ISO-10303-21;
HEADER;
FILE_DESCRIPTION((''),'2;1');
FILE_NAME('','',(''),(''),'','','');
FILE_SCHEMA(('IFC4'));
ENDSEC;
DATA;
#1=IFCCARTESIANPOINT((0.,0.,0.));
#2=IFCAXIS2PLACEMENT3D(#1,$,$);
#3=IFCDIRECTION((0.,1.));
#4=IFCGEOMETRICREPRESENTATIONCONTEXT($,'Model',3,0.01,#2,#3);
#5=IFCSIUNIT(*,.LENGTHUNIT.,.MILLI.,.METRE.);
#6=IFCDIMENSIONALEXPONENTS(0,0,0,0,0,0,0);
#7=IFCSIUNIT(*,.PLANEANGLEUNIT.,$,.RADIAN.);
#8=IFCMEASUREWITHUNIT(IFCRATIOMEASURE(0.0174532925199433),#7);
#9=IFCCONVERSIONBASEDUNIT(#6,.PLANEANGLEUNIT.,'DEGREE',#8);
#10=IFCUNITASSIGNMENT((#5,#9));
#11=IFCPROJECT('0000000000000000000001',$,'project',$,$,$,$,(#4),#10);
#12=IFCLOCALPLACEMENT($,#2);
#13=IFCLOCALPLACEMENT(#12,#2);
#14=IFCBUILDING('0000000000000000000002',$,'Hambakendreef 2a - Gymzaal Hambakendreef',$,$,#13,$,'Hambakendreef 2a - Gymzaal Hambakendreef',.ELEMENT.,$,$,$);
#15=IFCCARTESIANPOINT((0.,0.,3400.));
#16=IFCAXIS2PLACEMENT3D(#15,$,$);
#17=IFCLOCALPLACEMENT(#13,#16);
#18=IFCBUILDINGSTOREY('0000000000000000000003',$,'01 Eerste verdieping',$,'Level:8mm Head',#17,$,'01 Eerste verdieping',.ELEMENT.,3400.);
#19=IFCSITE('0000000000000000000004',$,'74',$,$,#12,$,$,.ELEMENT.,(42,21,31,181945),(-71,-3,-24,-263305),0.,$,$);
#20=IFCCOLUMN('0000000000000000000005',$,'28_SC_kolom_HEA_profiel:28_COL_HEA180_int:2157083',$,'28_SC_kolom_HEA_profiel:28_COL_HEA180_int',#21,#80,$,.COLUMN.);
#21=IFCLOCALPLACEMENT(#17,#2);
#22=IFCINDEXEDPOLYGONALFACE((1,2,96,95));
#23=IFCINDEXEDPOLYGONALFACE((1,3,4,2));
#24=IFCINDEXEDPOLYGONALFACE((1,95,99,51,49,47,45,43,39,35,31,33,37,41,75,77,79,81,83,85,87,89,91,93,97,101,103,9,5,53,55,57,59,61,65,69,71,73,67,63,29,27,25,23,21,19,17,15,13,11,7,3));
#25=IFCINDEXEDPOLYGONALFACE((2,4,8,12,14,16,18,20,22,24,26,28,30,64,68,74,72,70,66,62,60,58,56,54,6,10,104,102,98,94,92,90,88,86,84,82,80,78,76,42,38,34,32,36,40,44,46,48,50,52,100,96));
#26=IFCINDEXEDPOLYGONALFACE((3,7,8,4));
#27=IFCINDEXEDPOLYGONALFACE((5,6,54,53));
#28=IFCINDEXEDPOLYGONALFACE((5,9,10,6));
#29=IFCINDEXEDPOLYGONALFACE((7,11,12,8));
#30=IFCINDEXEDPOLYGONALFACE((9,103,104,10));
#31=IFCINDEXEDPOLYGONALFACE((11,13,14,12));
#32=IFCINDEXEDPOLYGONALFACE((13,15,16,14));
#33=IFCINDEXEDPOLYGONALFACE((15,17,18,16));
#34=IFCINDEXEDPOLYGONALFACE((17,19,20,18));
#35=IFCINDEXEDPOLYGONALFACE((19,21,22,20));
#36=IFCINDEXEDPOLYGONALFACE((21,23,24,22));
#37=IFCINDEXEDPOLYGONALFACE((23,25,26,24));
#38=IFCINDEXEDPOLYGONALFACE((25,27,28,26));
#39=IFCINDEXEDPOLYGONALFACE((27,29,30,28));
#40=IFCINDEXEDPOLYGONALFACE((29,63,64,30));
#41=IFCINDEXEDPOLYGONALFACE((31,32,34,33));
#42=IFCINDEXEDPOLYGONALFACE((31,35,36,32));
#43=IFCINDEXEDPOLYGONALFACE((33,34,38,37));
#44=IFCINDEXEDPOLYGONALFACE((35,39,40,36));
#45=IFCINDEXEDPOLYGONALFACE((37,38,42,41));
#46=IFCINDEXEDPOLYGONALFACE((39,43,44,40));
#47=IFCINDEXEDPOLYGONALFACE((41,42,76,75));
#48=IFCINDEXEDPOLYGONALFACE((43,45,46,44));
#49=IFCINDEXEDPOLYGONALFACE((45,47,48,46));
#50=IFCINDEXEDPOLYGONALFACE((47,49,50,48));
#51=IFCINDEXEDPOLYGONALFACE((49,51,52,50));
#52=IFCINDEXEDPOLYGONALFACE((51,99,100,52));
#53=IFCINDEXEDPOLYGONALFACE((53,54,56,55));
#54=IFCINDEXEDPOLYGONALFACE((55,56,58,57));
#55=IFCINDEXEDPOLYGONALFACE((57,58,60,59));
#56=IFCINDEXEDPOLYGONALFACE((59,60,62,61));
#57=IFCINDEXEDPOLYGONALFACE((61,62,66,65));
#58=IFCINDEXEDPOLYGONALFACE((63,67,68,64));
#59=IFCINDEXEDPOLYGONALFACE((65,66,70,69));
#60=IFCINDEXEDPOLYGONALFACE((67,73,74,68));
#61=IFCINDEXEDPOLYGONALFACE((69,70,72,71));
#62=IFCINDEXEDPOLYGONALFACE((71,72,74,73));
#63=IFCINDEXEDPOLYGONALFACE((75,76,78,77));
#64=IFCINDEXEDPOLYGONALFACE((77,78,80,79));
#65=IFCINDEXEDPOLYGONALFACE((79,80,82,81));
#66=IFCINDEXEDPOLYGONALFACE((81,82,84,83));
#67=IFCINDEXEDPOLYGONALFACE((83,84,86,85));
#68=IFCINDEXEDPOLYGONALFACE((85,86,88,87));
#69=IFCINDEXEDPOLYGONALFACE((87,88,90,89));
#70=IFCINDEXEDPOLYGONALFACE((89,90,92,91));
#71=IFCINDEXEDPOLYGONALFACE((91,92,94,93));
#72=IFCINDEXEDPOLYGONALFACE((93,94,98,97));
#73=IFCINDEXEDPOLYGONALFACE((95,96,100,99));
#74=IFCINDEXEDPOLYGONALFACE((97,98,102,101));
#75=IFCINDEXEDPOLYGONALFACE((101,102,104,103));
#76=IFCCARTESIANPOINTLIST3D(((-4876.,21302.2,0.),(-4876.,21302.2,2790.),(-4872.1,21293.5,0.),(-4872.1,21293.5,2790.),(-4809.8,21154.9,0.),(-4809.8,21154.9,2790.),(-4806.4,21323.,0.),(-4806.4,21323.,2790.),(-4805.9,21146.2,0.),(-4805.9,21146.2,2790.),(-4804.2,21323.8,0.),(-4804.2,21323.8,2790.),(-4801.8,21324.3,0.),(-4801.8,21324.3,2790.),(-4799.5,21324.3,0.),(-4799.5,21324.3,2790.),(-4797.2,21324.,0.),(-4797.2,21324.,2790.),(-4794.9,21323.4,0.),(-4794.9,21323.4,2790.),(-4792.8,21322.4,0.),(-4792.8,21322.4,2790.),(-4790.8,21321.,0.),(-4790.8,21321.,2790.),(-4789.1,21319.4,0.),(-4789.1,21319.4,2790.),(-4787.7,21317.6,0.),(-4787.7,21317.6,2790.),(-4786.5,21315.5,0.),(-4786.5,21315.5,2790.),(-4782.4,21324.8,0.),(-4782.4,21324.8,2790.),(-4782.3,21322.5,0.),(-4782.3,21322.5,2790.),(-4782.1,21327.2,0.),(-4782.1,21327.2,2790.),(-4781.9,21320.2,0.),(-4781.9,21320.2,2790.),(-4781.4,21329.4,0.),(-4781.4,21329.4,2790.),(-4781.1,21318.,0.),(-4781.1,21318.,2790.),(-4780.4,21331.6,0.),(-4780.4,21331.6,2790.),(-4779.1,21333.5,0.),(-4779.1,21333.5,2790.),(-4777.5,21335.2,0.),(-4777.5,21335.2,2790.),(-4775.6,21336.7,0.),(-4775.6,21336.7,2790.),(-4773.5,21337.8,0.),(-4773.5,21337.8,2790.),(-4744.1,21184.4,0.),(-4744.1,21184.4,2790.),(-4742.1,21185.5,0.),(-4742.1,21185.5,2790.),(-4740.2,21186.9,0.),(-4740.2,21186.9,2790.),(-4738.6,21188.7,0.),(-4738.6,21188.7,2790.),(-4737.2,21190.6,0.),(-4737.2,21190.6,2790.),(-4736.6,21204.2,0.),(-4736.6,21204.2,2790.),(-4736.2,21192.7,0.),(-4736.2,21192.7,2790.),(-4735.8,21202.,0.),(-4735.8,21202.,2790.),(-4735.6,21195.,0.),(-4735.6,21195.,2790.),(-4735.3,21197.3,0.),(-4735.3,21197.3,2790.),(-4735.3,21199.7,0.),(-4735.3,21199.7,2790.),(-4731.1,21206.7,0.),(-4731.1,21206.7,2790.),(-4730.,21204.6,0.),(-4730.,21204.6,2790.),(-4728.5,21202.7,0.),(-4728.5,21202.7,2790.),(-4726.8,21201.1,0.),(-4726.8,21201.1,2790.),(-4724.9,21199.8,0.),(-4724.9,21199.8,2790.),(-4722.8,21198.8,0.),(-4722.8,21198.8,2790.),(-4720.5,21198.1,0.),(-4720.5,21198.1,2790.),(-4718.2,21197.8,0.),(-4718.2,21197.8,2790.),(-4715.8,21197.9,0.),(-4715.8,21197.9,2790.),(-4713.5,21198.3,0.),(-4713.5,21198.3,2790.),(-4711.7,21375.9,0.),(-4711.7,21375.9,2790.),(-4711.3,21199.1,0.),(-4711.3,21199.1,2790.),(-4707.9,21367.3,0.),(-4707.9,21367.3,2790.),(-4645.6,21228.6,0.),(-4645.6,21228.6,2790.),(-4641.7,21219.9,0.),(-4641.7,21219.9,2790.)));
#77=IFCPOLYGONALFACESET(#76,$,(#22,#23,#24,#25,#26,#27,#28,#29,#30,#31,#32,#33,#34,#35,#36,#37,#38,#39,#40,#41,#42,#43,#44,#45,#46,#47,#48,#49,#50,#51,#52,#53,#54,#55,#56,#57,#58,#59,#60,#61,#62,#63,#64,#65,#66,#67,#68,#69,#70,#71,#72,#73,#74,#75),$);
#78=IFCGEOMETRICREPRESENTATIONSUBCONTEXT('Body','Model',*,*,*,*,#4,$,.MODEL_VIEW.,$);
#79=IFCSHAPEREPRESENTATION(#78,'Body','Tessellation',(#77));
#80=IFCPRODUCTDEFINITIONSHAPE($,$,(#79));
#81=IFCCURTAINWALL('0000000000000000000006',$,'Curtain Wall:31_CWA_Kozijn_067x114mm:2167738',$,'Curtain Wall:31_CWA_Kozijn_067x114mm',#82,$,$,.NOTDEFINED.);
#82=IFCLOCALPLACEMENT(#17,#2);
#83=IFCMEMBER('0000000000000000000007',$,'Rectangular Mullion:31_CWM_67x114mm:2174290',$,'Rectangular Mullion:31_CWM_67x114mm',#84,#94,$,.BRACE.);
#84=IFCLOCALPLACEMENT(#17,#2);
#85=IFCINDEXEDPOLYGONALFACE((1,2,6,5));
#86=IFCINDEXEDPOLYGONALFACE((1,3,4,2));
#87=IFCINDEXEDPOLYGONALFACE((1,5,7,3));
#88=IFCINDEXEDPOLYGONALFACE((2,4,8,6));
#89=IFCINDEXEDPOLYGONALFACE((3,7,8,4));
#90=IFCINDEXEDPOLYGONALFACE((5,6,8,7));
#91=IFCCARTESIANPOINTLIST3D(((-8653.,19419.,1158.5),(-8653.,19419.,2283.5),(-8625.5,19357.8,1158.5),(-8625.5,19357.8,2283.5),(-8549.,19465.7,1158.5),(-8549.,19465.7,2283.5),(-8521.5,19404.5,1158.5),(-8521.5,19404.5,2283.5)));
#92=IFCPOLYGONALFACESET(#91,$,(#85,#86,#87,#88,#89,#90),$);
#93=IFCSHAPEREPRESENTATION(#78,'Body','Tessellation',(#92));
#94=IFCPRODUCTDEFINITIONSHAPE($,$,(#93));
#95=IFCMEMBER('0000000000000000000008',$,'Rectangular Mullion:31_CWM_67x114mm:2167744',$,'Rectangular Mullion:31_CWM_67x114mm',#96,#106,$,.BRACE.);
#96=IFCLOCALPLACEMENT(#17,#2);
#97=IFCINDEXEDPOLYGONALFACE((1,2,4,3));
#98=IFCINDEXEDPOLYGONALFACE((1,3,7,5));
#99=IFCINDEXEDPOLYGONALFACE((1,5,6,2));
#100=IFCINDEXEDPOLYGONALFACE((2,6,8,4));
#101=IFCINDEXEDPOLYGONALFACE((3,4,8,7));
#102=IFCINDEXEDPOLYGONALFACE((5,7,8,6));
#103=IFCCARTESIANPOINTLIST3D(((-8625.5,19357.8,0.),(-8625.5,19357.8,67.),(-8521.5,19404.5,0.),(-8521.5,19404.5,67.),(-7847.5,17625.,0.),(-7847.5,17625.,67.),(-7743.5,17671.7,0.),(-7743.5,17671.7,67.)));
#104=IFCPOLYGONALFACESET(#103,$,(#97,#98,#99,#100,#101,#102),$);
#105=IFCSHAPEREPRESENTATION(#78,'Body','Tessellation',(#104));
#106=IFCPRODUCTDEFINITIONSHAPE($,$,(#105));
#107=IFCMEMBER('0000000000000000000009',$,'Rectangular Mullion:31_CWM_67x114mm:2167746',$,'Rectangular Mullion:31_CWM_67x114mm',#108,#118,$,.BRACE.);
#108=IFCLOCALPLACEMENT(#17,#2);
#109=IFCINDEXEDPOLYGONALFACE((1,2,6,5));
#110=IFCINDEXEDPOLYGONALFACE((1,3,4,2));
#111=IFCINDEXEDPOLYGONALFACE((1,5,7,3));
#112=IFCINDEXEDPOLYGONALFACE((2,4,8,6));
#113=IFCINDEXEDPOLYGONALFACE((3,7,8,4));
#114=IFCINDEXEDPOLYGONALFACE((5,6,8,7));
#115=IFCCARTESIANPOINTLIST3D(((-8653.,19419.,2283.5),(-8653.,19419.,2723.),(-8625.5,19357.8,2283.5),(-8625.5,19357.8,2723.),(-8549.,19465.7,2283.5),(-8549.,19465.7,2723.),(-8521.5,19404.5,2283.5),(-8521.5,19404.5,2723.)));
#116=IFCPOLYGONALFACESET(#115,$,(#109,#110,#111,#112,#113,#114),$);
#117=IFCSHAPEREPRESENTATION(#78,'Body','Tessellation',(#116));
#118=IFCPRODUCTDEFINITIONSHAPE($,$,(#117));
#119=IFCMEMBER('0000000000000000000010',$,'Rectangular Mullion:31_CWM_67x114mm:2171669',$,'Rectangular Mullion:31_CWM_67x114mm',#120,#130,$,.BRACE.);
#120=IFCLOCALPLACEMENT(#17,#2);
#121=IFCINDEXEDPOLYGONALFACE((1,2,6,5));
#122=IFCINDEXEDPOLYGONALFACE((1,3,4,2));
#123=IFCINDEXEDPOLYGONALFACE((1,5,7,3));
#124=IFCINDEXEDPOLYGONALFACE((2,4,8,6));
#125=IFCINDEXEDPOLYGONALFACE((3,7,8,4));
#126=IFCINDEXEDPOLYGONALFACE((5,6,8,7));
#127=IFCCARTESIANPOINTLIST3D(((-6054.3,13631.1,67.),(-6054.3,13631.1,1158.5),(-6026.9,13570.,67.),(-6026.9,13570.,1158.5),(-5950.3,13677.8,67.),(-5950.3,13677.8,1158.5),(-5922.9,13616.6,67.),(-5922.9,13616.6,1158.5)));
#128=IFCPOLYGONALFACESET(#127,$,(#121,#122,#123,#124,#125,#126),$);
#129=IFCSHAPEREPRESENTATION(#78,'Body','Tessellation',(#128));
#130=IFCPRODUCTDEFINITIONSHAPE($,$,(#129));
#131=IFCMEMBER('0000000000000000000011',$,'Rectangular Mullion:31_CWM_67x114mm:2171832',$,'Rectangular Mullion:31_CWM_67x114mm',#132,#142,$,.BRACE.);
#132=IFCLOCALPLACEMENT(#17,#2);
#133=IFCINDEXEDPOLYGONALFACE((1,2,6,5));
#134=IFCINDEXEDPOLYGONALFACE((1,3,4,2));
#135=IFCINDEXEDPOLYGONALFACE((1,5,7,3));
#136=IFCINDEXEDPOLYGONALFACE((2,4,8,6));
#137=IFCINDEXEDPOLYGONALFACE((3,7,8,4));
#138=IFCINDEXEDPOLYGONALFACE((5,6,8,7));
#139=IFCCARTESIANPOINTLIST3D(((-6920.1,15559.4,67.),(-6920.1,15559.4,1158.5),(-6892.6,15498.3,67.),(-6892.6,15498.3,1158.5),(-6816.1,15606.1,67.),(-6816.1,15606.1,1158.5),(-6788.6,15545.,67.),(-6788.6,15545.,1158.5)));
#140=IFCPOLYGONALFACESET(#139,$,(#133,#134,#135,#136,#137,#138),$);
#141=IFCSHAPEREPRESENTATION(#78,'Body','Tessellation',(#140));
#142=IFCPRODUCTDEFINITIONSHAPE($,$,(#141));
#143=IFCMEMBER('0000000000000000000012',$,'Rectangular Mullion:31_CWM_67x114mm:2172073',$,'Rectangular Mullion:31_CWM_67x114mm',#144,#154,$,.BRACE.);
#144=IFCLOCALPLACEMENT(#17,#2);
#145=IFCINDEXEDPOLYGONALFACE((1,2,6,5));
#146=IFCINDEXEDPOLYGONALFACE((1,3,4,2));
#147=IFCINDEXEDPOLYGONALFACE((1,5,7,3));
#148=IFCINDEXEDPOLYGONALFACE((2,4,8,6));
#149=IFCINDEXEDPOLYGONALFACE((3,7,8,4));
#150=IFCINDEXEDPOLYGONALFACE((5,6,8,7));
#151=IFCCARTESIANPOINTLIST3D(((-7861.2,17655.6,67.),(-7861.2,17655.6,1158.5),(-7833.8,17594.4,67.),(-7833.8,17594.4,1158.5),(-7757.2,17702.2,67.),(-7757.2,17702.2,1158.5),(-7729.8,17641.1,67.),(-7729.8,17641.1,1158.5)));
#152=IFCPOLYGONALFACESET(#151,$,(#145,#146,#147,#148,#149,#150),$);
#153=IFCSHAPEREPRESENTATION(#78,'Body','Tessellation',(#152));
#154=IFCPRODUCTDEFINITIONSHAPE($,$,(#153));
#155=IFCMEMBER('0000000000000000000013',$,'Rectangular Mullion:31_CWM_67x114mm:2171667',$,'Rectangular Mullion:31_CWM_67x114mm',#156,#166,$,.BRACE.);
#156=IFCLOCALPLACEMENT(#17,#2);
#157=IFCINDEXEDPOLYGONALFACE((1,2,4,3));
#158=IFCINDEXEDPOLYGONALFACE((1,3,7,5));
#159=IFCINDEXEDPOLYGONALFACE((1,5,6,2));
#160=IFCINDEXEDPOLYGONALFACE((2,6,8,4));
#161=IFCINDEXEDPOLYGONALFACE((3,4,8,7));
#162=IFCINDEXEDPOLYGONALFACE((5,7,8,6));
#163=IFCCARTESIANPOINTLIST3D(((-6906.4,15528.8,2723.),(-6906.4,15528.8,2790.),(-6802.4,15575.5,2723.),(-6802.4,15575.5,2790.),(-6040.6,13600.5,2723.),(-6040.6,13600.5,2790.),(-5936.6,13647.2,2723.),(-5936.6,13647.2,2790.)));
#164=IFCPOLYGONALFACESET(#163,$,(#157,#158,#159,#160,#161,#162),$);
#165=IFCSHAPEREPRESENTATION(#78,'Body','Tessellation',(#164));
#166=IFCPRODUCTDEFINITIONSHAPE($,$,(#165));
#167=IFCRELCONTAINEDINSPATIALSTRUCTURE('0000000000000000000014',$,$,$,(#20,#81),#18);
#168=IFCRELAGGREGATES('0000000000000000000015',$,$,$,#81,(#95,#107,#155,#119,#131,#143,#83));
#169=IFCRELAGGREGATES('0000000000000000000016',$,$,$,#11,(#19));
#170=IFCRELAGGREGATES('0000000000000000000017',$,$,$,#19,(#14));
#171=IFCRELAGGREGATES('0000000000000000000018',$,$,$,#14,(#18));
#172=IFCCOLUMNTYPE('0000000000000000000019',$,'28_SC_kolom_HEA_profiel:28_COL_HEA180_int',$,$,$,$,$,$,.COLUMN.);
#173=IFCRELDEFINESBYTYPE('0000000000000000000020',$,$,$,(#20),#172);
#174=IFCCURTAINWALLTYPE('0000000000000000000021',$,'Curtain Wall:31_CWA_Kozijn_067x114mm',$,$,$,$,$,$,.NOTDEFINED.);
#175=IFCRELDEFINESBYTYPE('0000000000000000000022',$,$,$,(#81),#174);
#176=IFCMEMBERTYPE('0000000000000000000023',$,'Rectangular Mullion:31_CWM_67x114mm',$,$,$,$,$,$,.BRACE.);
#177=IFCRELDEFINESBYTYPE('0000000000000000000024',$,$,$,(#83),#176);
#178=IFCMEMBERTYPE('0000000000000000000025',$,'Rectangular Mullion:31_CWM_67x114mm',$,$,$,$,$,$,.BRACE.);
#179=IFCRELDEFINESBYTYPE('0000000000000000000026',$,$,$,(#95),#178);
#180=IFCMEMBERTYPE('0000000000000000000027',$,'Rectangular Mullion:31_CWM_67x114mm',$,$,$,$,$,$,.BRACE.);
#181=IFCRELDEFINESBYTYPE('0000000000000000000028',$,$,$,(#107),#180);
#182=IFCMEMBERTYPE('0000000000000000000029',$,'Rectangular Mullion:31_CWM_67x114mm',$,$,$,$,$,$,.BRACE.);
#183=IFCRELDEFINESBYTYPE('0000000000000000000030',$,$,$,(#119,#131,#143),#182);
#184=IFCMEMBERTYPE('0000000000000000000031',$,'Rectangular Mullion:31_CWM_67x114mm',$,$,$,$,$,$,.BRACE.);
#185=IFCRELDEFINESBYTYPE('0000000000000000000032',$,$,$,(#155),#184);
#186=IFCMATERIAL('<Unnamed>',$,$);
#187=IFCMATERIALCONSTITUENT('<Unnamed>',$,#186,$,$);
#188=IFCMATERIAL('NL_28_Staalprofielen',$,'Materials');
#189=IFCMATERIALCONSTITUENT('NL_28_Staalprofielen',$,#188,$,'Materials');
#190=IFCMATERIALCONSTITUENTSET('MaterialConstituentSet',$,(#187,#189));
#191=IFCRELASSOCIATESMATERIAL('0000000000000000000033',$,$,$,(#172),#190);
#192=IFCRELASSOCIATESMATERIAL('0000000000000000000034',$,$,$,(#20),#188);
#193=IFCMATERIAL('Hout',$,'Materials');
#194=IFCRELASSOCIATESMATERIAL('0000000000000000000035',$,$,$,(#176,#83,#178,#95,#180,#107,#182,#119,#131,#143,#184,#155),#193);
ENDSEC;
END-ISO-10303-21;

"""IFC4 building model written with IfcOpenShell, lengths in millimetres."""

from ifc_helpers import new_model, entity, si_unit, converted_unit, direction, frame, origin, place, context, subcontext, project, spatial, indexed_curve, outline, extrude, source, transform, mapped, material, constituent, constituent_set, type_object, type_shapes, element, aggregate, save


model = new_model("IFC4")

# Units and contexts
model_context = context("Model", 3, precision=0.01, world=origin(), true_north=direction((0.0, 1.0)))
body_context = subcontext(model_context, "Body", "Model", "MODEL_VIEW")
ifc_project = project(units=[si_unit("LENGTHUNIT", "METRE", prefix="MILLI"), converted_unit("PLANEANGLEUNIT", "DEGREE", entity("IfcRatioMeasure", 0.0174532925199433), si_unit("PLANEANGLEUNIT", "RADIAN"), dimensions=[0, 0, 0, 0, 0, 0, 0])], contexts=[model_context])

# Site, building, storey
site_placement = place(None, origin())
site = spatial("IfcSite", under=ifc_project, at=site_placement, Name="74", CompositionType="ELEMENT", RefLatitude=(42, 21, 31, 181945), RefLongitude=(-71, -3, -24, -263305), RefElevation=0.0)
building_placement = place(site_placement, origin())
building = spatial("IfcBuilding", under=site, at=building_placement, Name="Hambakendreef 2a - Gymzaal Hambakendreef", LongName="Hambakendreef 2a - Gymzaal Hambakendreef", CompositionType="ELEMENT")
storey_placement = place(building_placement, frame((0.0, 0.0, 3400.0)))
storey = spatial("IfcBuildingStorey", under=building, at=storey_placement, Name="01 Eerste verdieping", ObjectType="Level:8mm Head", LongName="01 Eerste verdieping", CompositionType="ELEMENT", Elevation=3400.0)

# Column
ifc_material_1 = material(Name="<Unnamed>")
ifc_material_2 = material(Name="NL_28_Staalprofielen", Category="Materials")
ifc_constituent_1 = constituent(ifc_material_1, Name="<Unnamed>")
ifc_constituent_2 = constituent(ifc_material_2, Name="NL_28_Staalprofielen", Category="Materials")
ifc_constituent_set_1 = constituent_set(constituents=[ifc_constituent_1, ifc_constituent_2], Name="MaterialConstituentSet")
column_type_1 = type_object("IfcColumnType", Name="28_SC_kolom_HEA_profiel:28_COL_HEA180_int", PredefinedType="COLUMN", material=ifc_constituent_set_1)
shared_shape_1 = source(origin(), body_context, "Body", "SweptSolid", [
    extrude(outline(indexed_curve([(-85.5, -90.0), (-76.0, -90.0), (-76.0, -18.0), (-75.8, -15.7), (-75.3, -13.4), (-74.4, -11.2), (-73.1, -9.2), (-71.6, -7.4), (-69.8, -5.9), (-67.8, -4.6), (-65.6, -3.7), (-63.3, -3.2), (-61.0, -3.0), (61.0, -3.0), (63.3, -3.2), (65.6, -3.7), (67.8, -4.6), (69.8, -5.9), (71.6, -7.4), (73.1, -9.2), (74.4, -11.2), (75.3, -13.4), (75.8, -15.7), (76.0, -18.0), (76.0, -90.0), (85.5, -90.0), (85.5, 90.0), (76.0, 90.0), (76.0, 18.0), (75.8, 15.7), (75.3, 13.4), (74.4, 11.2), (73.1, 9.2), (71.6, 7.4), (69.8, 5.9), (67.8, 4.6), (65.6, 3.7), (63.3, 3.2), (61.0, 3.0), (-61.0, 3.0), (-63.3, 3.2), (-65.6, 3.7), (-67.8, 4.6), (-69.8, 5.9), (-71.6, 7.4), (-73.1, 9.2), (-74.4, 11.2), (-75.3, 13.4), (-75.8, 15.7), (-76.0, 18.0), (-76.0, 90.0), (-85.5, 90.0), (-85.5, -90.0)], self_intersect=False)), frame((0.0, 0.0, 3400.0), z_axis=(0.0, 0.0, 1.0), x_axis=(0.0, -1.0, 0.0)), (0.0, 0.0, 1.0), 2790.0),
])
type_shapes(column_type_1, [shared_shape_1])
for number, where, z_axis, x_axis, name in (
    (1, (-4758.8, 21261.1, -3400.0), (0.0, 0.0, 1.0), (0.91227, 0.40959, 0.0), "28_SC_kolom_HEA_profiel:28_COL_HEA180_int:2157083"),
):
    element("IfcColumn", number, at=place(storey_placement, frame(where, z_axis=z_axis, x_axis=x_axis)), inside=storey, type_object=column_type_1, material=ifc_material_2, Name=name, ObjectType="28_SC_kolom_HEA_profiel:28_COL_HEA180_int", PredefinedType="COLUMN", context=body_context, shape_type="MappedRepresentation", body=[
        mapped(shared_shape_1, transform((0.0, 0.0, 0.0), scale=1.0)),
    ])

# Curtain wall, members
curtain_wall_type = type_object("IfcCurtainWallType", Name="Curtain Wall:31_CWA_Kozijn_067x114mm", PredefinedType="NOTDEFINED")
curtain_wall_placement = place(storey_placement, frame((0.0, 0.0, -3400.0)))
curtain_wall = element("IfcCurtainWall", 2, at=curtain_wall_placement, inside=storey, type_object=curtain_wall_type, Name="Curtain Wall:31_CWA_Kozijn_067x114mm:2167738", ObjectType="Curtain Wall:31_CWA_Kozijn_067x114mm", PredefinedType="NOTDEFINED")
ifc_material_3 = material(Name="Hout", Category="Materials")
member_type_1 = type_object("IfcMemberType", Name="Rectangular Mullion:31_CWM_67x114mm", PredefinedType="BRACE", material=ifc_material_3)
shared_shape_2 = source(origin(), body_context, "Body", "SweptSolid", [
    extrude(outline(indexed_curve([(-57.0, -33.5), (57.0, -33.5), (57.0, 33.5), (-57.0, 33.5), (-57.0, -33.5)], self_intersect=False)), frame((-33.5, 0.0, -1125.0), z_axis=(0.0, 0.0, 1.0), x_axis=(0.0, -1.0, 0.0)), (0.0, 0.0, 1.0), 1125.0),
])
type_shapes(member_type_1, [shared_shape_2])
member_1_placement = place(storey_placement, frame((-8601.0, 19442.3, 2283.5), z_axis=(0.0, 0.0, 1.0), x_axis=(-0.40959, 0.91227, 0.0)))
member_1 = element("IfcMember", 3, at=member_1_placement, type_object=member_type_1, material=ifc_material_3, Name="Rectangular Mullion:31_CWM_67x114mm:2174290", ObjectType="Rectangular Mullion:31_CWM_67x114mm", PredefinedType="BRACE", context=body_context, shape_type="MappedRepresentation", body=[
    mapped(shared_shape_2, transform((0.0, 0.0, 0.0), scale=1.0)),
])
member_type_2 = type_object("IfcMemberType", Name="Rectangular Mullion:31_CWM_67x114mm", PredefinedType="BRACE", material=ifc_material_3)
shared_shape_3 = source(origin(), body_context, "Body", "SweptSolid", [
    extrude(outline(indexed_curve([(-57.0, -33.5), (57.0, -33.5), (57.0, 33.5), (-57.0, 33.5), (-57.0, -33.5)], self_intersect=False)), frame((-33.5, 0.0, -1899.5), z_axis=(0.0, 0.0, 1.0), x_axis=(0.0, -1.0, 0.0)), (0.0, 0.0, 1.0), 1899.5),
])
type_shapes(member_type_2, [shared_shape_3])
member_2_placement = place(storey_placement, frame((-8573.5, 19381.2, 0.0), z_axis=(-0.40959, 0.91227, 0.0), x_axis=(0.0, 0.0, -1.0)))
member_2 = element("IfcMember", 4, at=member_2_placement, type_object=member_type_2, material=ifc_material_3, Name="Rectangular Mullion:31_CWM_67x114mm:2167744", ObjectType="Rectangular Mullion:31_CWM_67x114mm", PredefinedType="BRACE", context=body_context, shape_type="MappedRepresentation", body=[
    mapped(shared_shape_3, transform((0.0, 0.0, 0.0), scale=1.0)),
])
member_type_3 = type_object("IfcMemberType", Name="Rectangular Mullion:31_CWM_67x114mm", PredefinedType="BRACE", material=ifc_material_3)
shared_shape_4 = source(origin(), body_context, "Body", "SweptSolid", [
    extrude(outline(indexed_curve([(-57.0, -33.5), (57.0, -33.5), (57.0, 33.5), (-57.0, 33.5), (-57.0, -33.5)], self_intersect=False)), frame((-33.5, 0.0, -439.5), z_axis=(0.0, 0.0, 1.0), x_axis=(0.0, -1.0, 0.0)), (0.0, 0.0, 1.0), 439.5),
])
type_shapes(member_type_3, [shared_shape_4])
member_3_placement = place(storey_placement, frame((-8601.0, 19442.3, 2723.0), z_axis=(0.0, 0.0, 1.0), x_axis=(-0.40959, 0.91227, 0.0)))
member_3 = element("IfcMember", 5, at=member_3_placement, type_object=member_type_3, material=ifc_material_3, Name="Rectangular Mullion:31_CWM_67x114mm:2167746", ObjectType="Rectangular Mullion:31_CWM_67x114mm", PredefinedType="BRACE", context=body_context, shape_type="MappedRepresentation", body=[
    mapped(shared_shape_4, transform((0.0, 0.0, 0.0), scale=1.0)),
])
member_type_4 = type_object("IfcMemberType", Name="Rectangular Mullion:31_CWM_67x114mm", PredefinedType="BRACE", material=ifc_material_3)
shared_shape_5 = source(origin(), body_context, "Body", "SweptSolid", [
    extrude(outline(indexed_curve([(-57.0, -33.5), (57.0, -33.5), (57.0, 33.5), (-57.0, 33.5), (-57.0, -33.5)], self_intersect=False)), frame((0.0, 0.0, -1091.5), z_axis=(0.0, 0.0, 1.0), x_axis=(0.0, -1.0, 0.0)), (0.0, 0.0, 1.0), 1091.5),
])
type_shapes(member_type_4, [shared_shape_5])
member_4_placement = place(storey_placement, frame((-5988.6, 13623.9, 67.0), z_axis=(0.0, 0.0, -1.0), x_axis=(0.40959, -0.91227, 0.0)))
member_4 = element("IfcMember", 6, at=member_4_placement, type_object=member_type_4, material=ifc_material_3, Name="Rectangular Mullion:31_CWM_67x114mm:2171669", ObjectType="Rectangular Mullion:31_CWM_67x114mm", PredefinedType="BRACE", context=body_context, shape_type="MappedRepresentation", body=[
    mapped(shared_shape_5, transform((0.0, 0.0, 0.0), scale=1.0)),
])
member_5_placement = place(storey_placement, frame((-6854.4, 15552.2, 67.0), z_axis=(0.0, 0.0, -1.0), x_axis=(0.40959, -0.91227, 0.0)))
member_5 = element("IfcMember", 7, at=member_5_placement, type_object=member_type_4, material=ifc_material_3, Name="Rectangular Mullion:31_CWM_67x114mm:2171832", ObjectType="Rectangular Mullion:31_CWM_67x114mm", PredefinedType="BRACE", context=body_context, shape_type="MappedRepresentation", body=[
    mapped(shared_shape_5, transform((0.0, 0.0, 0.0), scale=1.0)),
])
member_6_placement = place(storey_placement, frame((-7795.5, 17648.3, 67.0), z_axis=(0.0, 0.0, -1.0), x_axis=(0.40959, -0.91227, 0.0)))
member_6 = element("IfcMember", 8, at=member_6_placement, type_object=member_type_4, material=ifc_material_3, Name="Rectangular Mullion:31_CWM_67x114mm:2172073", ObjectType="Rectangular Mullion:31_CWM_67x114mm", PredefinedType="BRACE", context=body_context, shape_type="MappedRepresentation", body=[
    mapped(shared_shape_5, transform((0.0, 0.0, 0.0), scale=1.0)),
])
member_type_5 = type_object("IfcMemberType", Name="Rectangular Mullion:31_CWM_67x114mm", PredefinedType="BRACE", material=ifc_material_3)
shared_shape_6 = source(origin(), body_context, "Body", "SweptSolid", [
    extrude(outline(indexed_curve([(-57.0, -33.5), (57.0, -33.5), (57.0, 33.5), (-57.0, 33.5), (-57.0, -33.5)], self_intersect=False)), frame((-33.5, 0.0, -2113.8), z_axis=(0.0, 0.0, 1.0), x_axis=(0.0, -1.0, 0.0)), (0.0, 0.0, 1.0), 2113.8),
])
type_shapes(member_type_5, [shared_shape_6])
member_7_placement = place(storey_placement, frame((-5988.6, 13623.9, 2790.0), z_axis=(0.40959, -0.91227, 0.0), x_axis=(0.0, 0.0, 1.0)))
member_7 = element("IfcMember", 9, at=member_7_placement, type_object=member_type_5, material=ifc_material_3, Name="Rectangular Mullion:31_CWM_67x114mm:2171667", ObjectType="Rectangular Mullion:31_CWM_67x114mm", PredefinedType="BRACE", context=body_context, shape_type="MappedRepresentation", body=[
    mapped(shared_shape_6, transform((0.0, 0.0, 0.0), scale=1.0)),
])
aggregate(curtain_wall, [member_2, member_3, member_7, member_4, member_5, member_6, member_1])

save(model, "model.ifc")
